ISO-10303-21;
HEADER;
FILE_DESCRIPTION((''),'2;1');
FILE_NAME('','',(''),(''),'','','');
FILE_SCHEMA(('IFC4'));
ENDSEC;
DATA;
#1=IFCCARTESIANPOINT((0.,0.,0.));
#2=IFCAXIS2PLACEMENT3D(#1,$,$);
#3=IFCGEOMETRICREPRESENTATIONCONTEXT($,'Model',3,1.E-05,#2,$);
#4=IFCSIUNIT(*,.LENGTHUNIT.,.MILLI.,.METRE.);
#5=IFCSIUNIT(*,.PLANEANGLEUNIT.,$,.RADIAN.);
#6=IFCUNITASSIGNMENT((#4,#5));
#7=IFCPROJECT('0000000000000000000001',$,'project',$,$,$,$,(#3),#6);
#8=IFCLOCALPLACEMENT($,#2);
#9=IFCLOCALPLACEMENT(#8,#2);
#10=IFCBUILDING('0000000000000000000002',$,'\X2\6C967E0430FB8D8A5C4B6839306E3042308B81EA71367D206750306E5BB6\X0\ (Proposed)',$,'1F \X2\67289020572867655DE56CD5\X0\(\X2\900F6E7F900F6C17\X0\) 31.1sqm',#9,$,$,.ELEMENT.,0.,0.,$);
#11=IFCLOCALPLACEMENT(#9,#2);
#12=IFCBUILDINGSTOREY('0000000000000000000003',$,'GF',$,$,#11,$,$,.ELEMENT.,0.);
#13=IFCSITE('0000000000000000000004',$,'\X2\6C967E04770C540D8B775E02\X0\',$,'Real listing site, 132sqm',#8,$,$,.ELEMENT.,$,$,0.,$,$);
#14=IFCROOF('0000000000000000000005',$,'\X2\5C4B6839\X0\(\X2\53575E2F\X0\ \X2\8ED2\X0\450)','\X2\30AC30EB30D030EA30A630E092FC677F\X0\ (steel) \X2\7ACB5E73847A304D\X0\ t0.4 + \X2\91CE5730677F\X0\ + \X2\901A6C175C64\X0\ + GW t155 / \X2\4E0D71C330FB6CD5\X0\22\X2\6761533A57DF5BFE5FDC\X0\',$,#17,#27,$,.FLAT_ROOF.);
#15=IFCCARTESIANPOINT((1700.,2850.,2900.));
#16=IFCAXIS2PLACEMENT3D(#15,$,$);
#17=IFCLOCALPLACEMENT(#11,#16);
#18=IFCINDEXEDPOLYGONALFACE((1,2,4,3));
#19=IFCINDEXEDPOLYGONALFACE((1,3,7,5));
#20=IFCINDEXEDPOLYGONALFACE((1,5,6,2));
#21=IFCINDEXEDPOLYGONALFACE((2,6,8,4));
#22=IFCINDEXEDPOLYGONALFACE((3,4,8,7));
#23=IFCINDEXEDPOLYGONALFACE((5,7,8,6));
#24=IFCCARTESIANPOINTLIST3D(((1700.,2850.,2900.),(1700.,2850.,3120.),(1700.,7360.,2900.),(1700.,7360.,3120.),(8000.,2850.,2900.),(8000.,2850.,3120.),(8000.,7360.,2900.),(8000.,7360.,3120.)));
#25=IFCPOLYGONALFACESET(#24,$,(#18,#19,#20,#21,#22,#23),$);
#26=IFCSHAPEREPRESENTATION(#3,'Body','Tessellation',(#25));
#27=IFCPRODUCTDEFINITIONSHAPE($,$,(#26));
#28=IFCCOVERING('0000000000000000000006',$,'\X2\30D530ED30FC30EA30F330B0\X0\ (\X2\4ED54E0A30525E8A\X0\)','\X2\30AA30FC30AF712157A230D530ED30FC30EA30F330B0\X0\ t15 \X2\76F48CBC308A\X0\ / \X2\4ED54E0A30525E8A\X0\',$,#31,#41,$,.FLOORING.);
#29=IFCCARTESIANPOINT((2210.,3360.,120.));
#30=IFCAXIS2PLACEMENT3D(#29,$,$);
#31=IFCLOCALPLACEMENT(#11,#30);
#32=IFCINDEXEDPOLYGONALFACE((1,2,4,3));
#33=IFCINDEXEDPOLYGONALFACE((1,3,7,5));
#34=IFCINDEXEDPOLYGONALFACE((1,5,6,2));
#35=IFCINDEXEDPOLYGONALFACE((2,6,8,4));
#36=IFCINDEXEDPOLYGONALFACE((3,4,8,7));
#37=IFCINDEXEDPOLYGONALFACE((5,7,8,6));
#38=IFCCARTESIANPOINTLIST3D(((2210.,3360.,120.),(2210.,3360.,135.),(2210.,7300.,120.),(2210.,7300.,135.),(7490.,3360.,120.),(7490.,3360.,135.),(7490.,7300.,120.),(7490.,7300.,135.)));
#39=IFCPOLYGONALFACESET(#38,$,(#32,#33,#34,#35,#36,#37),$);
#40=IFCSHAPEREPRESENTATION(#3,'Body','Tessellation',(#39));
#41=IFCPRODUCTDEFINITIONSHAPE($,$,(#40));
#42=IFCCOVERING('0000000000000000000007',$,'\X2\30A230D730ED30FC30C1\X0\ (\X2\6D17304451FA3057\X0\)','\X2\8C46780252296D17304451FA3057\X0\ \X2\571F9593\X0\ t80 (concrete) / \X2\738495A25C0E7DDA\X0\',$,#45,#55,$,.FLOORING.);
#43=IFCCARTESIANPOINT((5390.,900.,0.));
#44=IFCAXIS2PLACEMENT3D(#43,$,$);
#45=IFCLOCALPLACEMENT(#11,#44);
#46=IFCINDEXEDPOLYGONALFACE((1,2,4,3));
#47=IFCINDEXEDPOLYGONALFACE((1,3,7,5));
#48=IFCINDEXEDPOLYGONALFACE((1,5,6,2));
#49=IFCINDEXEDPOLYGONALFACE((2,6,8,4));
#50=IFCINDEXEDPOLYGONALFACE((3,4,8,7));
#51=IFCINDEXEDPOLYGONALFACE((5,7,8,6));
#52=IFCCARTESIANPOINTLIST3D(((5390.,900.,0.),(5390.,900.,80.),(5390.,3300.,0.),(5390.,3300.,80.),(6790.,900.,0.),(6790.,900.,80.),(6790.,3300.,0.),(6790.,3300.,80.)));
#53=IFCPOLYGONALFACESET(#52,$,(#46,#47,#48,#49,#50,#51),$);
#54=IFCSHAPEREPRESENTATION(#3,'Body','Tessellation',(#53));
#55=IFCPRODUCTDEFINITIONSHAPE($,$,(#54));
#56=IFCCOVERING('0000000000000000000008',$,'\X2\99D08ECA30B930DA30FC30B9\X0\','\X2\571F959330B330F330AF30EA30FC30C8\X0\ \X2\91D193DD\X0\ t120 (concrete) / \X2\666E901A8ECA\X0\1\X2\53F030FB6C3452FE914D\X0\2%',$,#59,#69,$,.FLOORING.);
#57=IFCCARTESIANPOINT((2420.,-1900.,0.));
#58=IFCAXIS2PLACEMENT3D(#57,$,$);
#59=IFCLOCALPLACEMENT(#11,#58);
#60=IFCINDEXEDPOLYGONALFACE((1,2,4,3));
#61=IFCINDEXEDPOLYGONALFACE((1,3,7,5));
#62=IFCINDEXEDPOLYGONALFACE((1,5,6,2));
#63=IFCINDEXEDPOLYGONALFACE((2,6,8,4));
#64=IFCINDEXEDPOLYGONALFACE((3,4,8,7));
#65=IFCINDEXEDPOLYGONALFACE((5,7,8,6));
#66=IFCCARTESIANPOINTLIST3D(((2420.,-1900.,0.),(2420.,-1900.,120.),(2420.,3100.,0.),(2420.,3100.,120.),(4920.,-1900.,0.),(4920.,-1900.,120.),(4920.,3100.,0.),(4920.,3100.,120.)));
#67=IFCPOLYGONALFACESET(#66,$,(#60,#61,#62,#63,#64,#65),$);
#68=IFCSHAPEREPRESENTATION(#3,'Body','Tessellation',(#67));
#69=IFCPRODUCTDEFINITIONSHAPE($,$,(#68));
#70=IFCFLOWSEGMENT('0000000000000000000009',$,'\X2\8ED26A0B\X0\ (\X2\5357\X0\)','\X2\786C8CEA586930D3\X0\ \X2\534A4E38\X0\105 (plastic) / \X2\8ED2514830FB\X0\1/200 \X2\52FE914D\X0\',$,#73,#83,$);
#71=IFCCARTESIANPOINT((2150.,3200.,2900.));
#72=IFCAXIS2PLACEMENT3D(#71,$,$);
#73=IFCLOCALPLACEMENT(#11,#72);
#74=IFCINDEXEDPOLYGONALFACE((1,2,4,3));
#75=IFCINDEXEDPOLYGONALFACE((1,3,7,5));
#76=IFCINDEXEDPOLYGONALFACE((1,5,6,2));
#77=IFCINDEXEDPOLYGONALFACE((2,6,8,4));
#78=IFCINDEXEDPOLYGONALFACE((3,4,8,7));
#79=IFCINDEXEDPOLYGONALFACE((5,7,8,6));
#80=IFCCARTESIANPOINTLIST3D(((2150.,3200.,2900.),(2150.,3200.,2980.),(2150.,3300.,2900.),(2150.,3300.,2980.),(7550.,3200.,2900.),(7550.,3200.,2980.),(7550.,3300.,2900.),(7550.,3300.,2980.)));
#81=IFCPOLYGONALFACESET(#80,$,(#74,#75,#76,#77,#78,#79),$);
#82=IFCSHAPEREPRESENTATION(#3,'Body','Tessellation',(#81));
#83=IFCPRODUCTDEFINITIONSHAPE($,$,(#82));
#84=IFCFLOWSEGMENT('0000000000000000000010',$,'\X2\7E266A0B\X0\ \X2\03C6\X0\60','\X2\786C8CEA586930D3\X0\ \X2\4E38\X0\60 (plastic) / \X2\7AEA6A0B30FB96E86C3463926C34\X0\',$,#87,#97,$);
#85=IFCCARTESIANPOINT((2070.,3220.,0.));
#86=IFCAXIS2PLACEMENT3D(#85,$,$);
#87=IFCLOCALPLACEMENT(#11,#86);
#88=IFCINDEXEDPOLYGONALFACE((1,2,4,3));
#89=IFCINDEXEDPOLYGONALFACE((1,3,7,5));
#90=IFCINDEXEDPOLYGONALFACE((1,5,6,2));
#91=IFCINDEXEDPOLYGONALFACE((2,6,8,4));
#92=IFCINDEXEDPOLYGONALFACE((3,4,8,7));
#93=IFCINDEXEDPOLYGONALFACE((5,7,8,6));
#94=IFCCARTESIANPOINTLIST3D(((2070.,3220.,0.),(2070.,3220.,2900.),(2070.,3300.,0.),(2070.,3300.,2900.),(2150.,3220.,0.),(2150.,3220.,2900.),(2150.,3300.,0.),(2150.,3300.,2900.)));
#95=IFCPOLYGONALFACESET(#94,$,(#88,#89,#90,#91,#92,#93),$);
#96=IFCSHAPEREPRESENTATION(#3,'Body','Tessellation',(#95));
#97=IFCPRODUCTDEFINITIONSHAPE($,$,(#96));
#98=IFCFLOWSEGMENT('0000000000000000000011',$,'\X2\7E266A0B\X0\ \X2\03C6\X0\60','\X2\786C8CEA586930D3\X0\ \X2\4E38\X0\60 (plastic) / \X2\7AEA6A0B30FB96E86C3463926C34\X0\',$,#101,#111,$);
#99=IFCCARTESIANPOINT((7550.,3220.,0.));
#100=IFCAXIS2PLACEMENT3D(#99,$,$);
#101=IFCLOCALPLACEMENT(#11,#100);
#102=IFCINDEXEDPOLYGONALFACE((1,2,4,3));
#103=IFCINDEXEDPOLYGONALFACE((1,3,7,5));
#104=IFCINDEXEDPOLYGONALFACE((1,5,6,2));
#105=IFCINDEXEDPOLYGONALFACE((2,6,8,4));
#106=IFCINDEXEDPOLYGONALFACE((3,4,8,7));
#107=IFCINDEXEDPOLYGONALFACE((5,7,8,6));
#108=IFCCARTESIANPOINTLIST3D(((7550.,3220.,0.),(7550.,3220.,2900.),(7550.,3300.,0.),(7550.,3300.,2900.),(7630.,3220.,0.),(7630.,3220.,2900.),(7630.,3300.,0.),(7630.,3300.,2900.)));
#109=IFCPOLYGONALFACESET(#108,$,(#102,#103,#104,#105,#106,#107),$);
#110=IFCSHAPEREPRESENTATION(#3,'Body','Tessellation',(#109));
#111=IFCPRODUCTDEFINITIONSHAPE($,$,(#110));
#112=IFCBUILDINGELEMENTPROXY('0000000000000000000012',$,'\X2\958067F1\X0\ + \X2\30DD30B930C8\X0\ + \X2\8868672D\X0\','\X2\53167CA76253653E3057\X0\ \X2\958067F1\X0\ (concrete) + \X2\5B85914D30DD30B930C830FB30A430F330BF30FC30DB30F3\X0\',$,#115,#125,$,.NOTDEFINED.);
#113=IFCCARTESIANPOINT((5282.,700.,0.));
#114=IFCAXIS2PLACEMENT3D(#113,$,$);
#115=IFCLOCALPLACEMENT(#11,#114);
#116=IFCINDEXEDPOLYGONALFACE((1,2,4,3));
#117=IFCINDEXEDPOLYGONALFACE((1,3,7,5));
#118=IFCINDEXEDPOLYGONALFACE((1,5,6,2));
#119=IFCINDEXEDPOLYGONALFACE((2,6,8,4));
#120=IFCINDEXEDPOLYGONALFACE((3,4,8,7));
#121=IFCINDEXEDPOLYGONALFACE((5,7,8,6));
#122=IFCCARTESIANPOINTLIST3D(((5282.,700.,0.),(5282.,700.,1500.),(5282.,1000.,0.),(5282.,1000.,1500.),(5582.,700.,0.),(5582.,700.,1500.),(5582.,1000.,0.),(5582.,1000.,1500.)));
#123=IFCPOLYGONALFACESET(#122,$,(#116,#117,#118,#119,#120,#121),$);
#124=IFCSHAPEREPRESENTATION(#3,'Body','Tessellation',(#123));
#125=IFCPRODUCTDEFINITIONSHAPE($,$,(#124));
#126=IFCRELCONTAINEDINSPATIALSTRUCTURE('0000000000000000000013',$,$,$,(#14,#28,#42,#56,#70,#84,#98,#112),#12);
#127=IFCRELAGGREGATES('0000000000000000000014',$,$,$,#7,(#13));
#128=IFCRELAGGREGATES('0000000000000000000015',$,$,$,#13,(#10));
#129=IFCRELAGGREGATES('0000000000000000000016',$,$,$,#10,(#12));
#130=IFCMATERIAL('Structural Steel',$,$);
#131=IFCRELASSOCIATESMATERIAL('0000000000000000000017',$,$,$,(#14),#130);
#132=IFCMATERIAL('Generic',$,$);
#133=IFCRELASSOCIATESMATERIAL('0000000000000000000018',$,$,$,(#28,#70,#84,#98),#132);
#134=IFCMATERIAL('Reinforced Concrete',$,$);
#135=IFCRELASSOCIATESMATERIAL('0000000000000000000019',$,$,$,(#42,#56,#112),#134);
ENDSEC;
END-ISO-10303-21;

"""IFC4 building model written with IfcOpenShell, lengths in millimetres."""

from ifc_helpers import new_model, si_unit, frame, frame_2d, origin, place, context, project, spatial, rectangle, extrude, material, element, save


model = new_model("IFC4")

# Units and contexts
model_context = context("Model", 3, precision=1e-05, world=origin())
ifc_project = project(units=[si_unit("LENGTHUNIT", "METRE", prefix="MILLI"), si_unit("PLANEANGLEUNIT", "RADIAN")], contexts=[model_context])

# Site, building, storey
site_placement = place(None, origin())
site = spatial("IfcSite", under=ifc_project, at=site_placement, Name="沖縄県名護市", ObjectType="Real listing site, 132sqm", CompositionType="ELEMENT", RefElevation=0.0)
building_placement = place(site_placement, origin())
building = spatial("IfcBuilding", under=site, at=building_placement, Name="沖縄・越屋根のある自然素材の家 (Proposed)", ObjectType="1F 木造在来工法(透湿透気) 31.1sqm", CompositionType="ELEMENT", ElevationOfRefHeight=0.0, ElevationOfTerrain=0.0)
storey_placement = place(building_placement, origin())
storey = spatial("IfcBuildingStorey", under=building, at=storey_placement, Name="GF", CompositionType="ELEMENT", Elevation=0.0)

# Shared definitions
ifc_material_1 = material(Name="Reinforced Concrete")

# Roof
ifc_material_2 = material(Name="Structural Steel")
roof_placement = place(storey_placement, frame((1700.0, 2850.0, 2900.0)))
element("IfcRoof", 1, at=roof_placement, inside=storey, material=ifc_material_2, Name="屋根(南帯 軒450)", Description="ガルバリウム鋼板 (steel) 立平葺き t0.4 + 野地板 + 通気層 + GW t155 / 不燃・法22条区域対応", PredefinedType="FLAT_ROOF", context=model_context, shape_type="SweptSolid", body=[
    extrude(rectangle(XDim=6300.0, YDim=4510.0, at=frame_2d((3150.0, 2255.0))), frame((1700.0, 2850.0, 2900.0)), (0.0, 0.0, 1.0), 220.0),
])

# Coverings
ifc_material_3 = material(Name="Generic")
covering_1_placement = place(storey_placement, frame((2210.0, 3360.0, 120.0)))
element("IfcCovering", 2, at=covering_1_placement, inside=storey, material=ifc_material_3, Name="フローリング (仕上げ床)", Description="オーク無垢フローリング t15 直貼り / 仕上げ床", PredefinedType="FLOORING", context=model_context, shape_type="SweptSolid", body=[
    extrude(rectangle(XDim=5280.0, YDim=3940.0, at=frame_2d((2640.0, 1970.0))), frame((2210.0, 3360.0, 120.0)), (0.0, 0.0, 1.0), 15.0),
])
covering_2_placement = place(storey_placement, frame((5390.0, 900.0, 0.0)))
element("IfcCovering", 3, at=covering_2_placement, inside=storey, material=ifc_material_1, Name="アプローチ (洗い出し)", Description="豆砂利洗い出し 土間 t80 (concrete) / 玄関導線", PredefinedType="FLOORING", context=model_context, shape_type="SweptSolid", body=[
    extrude(rectangle(XDim=1400.0, YDim=2400.0, at=frame_2d((700.0, 1200.0))), frame((5390.0, 900.0, 0.0)), (0.0, 0.0, 1.0), 80.0),
])
covering_3_placement = place(storey_placement, frame((2420.0, -1900.0, 0.0)))
element("IfcCovering", 4, at=covering_3_placement, inside=storey, material=ifc_material_1, Name="駐車スペース", Description="土間コンクリート 金鏝 t120 (concrete) / 普通車1台・水勾配2%", PredefinedType="FLOORING", context=model_context, shape_type="SweptSolid", body=[
    extrude(rectangle(XDim=2500.0, YDim=5000.0, at=frame_2d((1250.0, 2500.0))), frame((2420.0, -1900.0, 0.0)), (0.0, 0.0, 1.0), 120.0),
])

# Flow segments
flow_segment_1_placement = place(storey_placement, frame((2150.0, 3200.0, 2900.0)))
element("IfcFlowSegment", 5, at=flow_segment_1_placement, inside=storey, material=ifc_material_3, Name="軒樋 (南)", Description="硬質塩ビ 半丸105 (plastic) / 軒先・1/200 勾配", context=model_context, shape_type="SweptSolid", body=[
    extrude(rectangle(XDim=5400.0, YDim=100.0, at=frame_2d((2700.0, 50.0))), frame((2150.0, 3200.0, 2900.0)), (0.0, 0.0, 1.0), 80.0),
])
flow_segment_2_placement = place(storey_placement, frame((2070.0, 3220.0, 0.0)))
element("IfcFlowSegment", 6, at=flow_segment_2_placement, inside=storey, material=ifc_material_3, Name="縦樋 φ60", Description="硬質塩ビ 丸60 (plastic) / 竪樋・雨水排水", context=model_context, shape_type="SweptSolid", body=[
    extrude(rectangle(XDim=80.0, YDim=80.0, at=frame_2d((40.0, 40.0))), frame((2070.0, 3220.0, 0.0)), (0.0, 0.0, 1.0), 2900.0),
])
flow_segment_3_placement = place(storey_placement, frame((7550.0, 3220.0, 0.0)))
element("IfcFlowSegment", 7, at=flow_segment_3_placement, inside=storey, material=ifc_material_3, Name="縦樋 φ60", Description="硬質塩ビ 丸60 (plastic) / 竪樋・雨水排水", context=model_context, shape_type="SweptSolid", body=[
    extrude(rectangle(XDim=80.0, YDim=80.0, at=frame_2d((40.0, 40.0))), frame((7550.0, 3220.0, 0.0)), (0.0, 0.0, 1.0), 2900.0),
])

# Building element proxy
proxy_placement = place(storey_placement, frame((5282.0, 700.0, 0.0)))
element("IfcBuildingElementProxy", 8, at=proxy_placement, inside=storey, material=ifc_material_1, Name="門柱 + ポスト + 表札", Description="化粧打放し 門柱 (concrete) + 宅配ポスト・インターホン", PredefinedType="NOTDEFINED", context=model_context, shape_type="SweptSolid", body=[
    extrude(rectangle(XDim=300.0, YDim=300.0, at=frame_2d((150.0, 150.0))), frame((5282.0, 700.0, 0.0)), (0.0, 0.0, 1.0), 1500.0),
])

save(model, "model.ifc")
